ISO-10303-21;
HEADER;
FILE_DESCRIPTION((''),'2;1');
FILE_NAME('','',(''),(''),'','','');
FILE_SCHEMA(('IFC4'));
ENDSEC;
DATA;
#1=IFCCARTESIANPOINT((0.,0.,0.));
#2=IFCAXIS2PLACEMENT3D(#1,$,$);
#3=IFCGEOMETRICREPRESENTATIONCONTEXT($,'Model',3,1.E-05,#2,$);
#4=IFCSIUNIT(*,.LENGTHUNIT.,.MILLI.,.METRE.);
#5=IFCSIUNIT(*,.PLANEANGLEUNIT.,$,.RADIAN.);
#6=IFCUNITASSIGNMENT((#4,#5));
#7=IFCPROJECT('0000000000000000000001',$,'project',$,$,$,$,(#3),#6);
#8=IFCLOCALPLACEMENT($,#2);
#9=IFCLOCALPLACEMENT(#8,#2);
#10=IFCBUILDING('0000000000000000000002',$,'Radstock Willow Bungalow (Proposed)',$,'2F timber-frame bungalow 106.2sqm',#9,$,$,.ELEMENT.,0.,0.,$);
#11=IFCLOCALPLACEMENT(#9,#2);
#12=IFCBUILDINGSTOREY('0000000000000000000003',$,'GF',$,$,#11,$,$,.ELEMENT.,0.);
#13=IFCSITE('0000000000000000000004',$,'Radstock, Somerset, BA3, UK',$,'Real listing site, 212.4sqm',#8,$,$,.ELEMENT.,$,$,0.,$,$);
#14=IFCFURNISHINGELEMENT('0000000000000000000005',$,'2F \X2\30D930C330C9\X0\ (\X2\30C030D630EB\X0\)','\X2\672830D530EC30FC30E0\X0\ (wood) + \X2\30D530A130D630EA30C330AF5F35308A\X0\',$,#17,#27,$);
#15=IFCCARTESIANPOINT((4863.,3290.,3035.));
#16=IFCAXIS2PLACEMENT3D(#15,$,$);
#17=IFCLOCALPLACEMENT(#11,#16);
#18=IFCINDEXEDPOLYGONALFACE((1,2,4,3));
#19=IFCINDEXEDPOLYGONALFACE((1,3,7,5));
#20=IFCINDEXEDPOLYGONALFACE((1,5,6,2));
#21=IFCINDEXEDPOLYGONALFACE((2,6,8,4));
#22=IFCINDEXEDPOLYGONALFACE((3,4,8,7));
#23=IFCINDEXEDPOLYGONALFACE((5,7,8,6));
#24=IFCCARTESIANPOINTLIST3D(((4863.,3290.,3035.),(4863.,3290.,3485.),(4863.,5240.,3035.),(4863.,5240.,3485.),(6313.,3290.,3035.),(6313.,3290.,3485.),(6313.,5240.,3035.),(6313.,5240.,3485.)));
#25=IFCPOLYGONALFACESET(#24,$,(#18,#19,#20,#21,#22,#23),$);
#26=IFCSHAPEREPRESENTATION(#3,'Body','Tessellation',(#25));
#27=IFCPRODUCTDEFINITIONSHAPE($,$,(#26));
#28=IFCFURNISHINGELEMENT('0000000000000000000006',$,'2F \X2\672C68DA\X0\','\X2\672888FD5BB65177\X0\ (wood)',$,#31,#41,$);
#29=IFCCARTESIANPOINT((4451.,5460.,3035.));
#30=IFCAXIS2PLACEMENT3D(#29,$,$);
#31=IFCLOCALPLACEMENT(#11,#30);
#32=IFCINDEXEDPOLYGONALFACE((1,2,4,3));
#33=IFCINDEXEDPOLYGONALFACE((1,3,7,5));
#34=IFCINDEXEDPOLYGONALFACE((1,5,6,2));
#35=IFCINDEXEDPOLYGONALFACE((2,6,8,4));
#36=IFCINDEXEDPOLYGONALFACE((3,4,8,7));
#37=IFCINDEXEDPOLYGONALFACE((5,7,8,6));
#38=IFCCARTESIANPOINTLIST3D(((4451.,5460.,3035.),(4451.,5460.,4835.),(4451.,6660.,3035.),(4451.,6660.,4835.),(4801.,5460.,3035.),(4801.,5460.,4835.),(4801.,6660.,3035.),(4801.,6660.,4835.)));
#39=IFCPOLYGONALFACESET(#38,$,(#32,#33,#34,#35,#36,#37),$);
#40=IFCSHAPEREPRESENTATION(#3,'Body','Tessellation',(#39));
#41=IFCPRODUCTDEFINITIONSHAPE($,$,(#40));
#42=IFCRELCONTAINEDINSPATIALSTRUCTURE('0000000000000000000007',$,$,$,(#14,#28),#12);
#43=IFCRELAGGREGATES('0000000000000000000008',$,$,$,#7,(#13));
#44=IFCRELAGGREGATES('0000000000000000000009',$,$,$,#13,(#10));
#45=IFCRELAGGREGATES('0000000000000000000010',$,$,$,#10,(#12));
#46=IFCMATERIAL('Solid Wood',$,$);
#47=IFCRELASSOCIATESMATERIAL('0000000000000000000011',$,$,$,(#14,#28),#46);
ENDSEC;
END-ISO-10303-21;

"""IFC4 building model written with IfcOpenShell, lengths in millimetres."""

from ifc_helpers import new_model, si_unit, frame, frame_2d, origin, place, context, project, spatial, rectangle, extrude, material, element, save


model = new_model("IFC4")

# Units and contexts
model_context = context("Model", 3, precision=1e-05, world=origin())
ifc_project = project(units=[si_unit("LENGTHUNIT", "METRE", prefix="MILLI"), si_unit("PLANEANGLEUNIT", "RADIAN")], contexts=[model_context])

# Site, building, storey
site_placement = place(None, origin())
site = spatial("IfcSite", under=ifc_project, at=site_placement, Name="Radstock, Somerset, BA3, UK", ObjectType="Real listing site, 212.4sqm", CompositionType="ELEMENT", RefElevation=0.0)
building_placement = place(site_placement, origin())
building = spatial("IfcBuilding", under=site, at=building_placement, Name="Radstock Willow Bungalow (Proposed)", ObjectType="2F timber-frame bungalow 106.2sqm", CompositionType="ELEMENT", ElevationOfRefHeight=0.0, ElevationOfTerrain=0.0)
storey_placement = place(building_placement, origin())
storey = spatial("IfcBuildingStorey", under=building, at=storey_placement, Name="GF", CompositionType="ELEMENT", Elevation=0.0)

# Shared definitions
ifc_material_1 = material(Name="Solid Wood")

# Furnishing elements
furnishing_1_placement = place(storey_placement, frame((4863.0, 3290.0, 3035.0)))
element("IfcFurnishingElement", 1, at=furnishing_1_placement, inside=storey, material=ifc_material_1, Name="2F ベッド (ダブル)", Description="木フレーム (wood) + ファブリック張り", context=model_context, shape_type="SweptSolid", body=[
    extrude(rectangle(XDim=1450.0, YDim=1950.0, at=frame_2d((725.0, 975.0))), frame((4863.0, 3290.0, 3035.0)), (0.0, 0.0, 1.0), 450.0),
])
furnishing_2_placement = place(storey_placement, frame((4451.0, 5460.0, 3035.0)))
element("IfcFurnishingElement", 2, at=furnishing_2_placement, inside=storey, material=ifc_material_1, Name="2F 本棚", Description="木製家具 (wood)", context=model_context, shape_type="SweptSolid", body=[
    extrude(rectangle(XDim=350.0, YDim=1200.0, at=frame_2d((175.0, 600.0))), frame((4451.0, 5460.0, 3035.0)), (0.0, 0.0, 1.0), 1800.0),
])

save(model, "model.ifc")
